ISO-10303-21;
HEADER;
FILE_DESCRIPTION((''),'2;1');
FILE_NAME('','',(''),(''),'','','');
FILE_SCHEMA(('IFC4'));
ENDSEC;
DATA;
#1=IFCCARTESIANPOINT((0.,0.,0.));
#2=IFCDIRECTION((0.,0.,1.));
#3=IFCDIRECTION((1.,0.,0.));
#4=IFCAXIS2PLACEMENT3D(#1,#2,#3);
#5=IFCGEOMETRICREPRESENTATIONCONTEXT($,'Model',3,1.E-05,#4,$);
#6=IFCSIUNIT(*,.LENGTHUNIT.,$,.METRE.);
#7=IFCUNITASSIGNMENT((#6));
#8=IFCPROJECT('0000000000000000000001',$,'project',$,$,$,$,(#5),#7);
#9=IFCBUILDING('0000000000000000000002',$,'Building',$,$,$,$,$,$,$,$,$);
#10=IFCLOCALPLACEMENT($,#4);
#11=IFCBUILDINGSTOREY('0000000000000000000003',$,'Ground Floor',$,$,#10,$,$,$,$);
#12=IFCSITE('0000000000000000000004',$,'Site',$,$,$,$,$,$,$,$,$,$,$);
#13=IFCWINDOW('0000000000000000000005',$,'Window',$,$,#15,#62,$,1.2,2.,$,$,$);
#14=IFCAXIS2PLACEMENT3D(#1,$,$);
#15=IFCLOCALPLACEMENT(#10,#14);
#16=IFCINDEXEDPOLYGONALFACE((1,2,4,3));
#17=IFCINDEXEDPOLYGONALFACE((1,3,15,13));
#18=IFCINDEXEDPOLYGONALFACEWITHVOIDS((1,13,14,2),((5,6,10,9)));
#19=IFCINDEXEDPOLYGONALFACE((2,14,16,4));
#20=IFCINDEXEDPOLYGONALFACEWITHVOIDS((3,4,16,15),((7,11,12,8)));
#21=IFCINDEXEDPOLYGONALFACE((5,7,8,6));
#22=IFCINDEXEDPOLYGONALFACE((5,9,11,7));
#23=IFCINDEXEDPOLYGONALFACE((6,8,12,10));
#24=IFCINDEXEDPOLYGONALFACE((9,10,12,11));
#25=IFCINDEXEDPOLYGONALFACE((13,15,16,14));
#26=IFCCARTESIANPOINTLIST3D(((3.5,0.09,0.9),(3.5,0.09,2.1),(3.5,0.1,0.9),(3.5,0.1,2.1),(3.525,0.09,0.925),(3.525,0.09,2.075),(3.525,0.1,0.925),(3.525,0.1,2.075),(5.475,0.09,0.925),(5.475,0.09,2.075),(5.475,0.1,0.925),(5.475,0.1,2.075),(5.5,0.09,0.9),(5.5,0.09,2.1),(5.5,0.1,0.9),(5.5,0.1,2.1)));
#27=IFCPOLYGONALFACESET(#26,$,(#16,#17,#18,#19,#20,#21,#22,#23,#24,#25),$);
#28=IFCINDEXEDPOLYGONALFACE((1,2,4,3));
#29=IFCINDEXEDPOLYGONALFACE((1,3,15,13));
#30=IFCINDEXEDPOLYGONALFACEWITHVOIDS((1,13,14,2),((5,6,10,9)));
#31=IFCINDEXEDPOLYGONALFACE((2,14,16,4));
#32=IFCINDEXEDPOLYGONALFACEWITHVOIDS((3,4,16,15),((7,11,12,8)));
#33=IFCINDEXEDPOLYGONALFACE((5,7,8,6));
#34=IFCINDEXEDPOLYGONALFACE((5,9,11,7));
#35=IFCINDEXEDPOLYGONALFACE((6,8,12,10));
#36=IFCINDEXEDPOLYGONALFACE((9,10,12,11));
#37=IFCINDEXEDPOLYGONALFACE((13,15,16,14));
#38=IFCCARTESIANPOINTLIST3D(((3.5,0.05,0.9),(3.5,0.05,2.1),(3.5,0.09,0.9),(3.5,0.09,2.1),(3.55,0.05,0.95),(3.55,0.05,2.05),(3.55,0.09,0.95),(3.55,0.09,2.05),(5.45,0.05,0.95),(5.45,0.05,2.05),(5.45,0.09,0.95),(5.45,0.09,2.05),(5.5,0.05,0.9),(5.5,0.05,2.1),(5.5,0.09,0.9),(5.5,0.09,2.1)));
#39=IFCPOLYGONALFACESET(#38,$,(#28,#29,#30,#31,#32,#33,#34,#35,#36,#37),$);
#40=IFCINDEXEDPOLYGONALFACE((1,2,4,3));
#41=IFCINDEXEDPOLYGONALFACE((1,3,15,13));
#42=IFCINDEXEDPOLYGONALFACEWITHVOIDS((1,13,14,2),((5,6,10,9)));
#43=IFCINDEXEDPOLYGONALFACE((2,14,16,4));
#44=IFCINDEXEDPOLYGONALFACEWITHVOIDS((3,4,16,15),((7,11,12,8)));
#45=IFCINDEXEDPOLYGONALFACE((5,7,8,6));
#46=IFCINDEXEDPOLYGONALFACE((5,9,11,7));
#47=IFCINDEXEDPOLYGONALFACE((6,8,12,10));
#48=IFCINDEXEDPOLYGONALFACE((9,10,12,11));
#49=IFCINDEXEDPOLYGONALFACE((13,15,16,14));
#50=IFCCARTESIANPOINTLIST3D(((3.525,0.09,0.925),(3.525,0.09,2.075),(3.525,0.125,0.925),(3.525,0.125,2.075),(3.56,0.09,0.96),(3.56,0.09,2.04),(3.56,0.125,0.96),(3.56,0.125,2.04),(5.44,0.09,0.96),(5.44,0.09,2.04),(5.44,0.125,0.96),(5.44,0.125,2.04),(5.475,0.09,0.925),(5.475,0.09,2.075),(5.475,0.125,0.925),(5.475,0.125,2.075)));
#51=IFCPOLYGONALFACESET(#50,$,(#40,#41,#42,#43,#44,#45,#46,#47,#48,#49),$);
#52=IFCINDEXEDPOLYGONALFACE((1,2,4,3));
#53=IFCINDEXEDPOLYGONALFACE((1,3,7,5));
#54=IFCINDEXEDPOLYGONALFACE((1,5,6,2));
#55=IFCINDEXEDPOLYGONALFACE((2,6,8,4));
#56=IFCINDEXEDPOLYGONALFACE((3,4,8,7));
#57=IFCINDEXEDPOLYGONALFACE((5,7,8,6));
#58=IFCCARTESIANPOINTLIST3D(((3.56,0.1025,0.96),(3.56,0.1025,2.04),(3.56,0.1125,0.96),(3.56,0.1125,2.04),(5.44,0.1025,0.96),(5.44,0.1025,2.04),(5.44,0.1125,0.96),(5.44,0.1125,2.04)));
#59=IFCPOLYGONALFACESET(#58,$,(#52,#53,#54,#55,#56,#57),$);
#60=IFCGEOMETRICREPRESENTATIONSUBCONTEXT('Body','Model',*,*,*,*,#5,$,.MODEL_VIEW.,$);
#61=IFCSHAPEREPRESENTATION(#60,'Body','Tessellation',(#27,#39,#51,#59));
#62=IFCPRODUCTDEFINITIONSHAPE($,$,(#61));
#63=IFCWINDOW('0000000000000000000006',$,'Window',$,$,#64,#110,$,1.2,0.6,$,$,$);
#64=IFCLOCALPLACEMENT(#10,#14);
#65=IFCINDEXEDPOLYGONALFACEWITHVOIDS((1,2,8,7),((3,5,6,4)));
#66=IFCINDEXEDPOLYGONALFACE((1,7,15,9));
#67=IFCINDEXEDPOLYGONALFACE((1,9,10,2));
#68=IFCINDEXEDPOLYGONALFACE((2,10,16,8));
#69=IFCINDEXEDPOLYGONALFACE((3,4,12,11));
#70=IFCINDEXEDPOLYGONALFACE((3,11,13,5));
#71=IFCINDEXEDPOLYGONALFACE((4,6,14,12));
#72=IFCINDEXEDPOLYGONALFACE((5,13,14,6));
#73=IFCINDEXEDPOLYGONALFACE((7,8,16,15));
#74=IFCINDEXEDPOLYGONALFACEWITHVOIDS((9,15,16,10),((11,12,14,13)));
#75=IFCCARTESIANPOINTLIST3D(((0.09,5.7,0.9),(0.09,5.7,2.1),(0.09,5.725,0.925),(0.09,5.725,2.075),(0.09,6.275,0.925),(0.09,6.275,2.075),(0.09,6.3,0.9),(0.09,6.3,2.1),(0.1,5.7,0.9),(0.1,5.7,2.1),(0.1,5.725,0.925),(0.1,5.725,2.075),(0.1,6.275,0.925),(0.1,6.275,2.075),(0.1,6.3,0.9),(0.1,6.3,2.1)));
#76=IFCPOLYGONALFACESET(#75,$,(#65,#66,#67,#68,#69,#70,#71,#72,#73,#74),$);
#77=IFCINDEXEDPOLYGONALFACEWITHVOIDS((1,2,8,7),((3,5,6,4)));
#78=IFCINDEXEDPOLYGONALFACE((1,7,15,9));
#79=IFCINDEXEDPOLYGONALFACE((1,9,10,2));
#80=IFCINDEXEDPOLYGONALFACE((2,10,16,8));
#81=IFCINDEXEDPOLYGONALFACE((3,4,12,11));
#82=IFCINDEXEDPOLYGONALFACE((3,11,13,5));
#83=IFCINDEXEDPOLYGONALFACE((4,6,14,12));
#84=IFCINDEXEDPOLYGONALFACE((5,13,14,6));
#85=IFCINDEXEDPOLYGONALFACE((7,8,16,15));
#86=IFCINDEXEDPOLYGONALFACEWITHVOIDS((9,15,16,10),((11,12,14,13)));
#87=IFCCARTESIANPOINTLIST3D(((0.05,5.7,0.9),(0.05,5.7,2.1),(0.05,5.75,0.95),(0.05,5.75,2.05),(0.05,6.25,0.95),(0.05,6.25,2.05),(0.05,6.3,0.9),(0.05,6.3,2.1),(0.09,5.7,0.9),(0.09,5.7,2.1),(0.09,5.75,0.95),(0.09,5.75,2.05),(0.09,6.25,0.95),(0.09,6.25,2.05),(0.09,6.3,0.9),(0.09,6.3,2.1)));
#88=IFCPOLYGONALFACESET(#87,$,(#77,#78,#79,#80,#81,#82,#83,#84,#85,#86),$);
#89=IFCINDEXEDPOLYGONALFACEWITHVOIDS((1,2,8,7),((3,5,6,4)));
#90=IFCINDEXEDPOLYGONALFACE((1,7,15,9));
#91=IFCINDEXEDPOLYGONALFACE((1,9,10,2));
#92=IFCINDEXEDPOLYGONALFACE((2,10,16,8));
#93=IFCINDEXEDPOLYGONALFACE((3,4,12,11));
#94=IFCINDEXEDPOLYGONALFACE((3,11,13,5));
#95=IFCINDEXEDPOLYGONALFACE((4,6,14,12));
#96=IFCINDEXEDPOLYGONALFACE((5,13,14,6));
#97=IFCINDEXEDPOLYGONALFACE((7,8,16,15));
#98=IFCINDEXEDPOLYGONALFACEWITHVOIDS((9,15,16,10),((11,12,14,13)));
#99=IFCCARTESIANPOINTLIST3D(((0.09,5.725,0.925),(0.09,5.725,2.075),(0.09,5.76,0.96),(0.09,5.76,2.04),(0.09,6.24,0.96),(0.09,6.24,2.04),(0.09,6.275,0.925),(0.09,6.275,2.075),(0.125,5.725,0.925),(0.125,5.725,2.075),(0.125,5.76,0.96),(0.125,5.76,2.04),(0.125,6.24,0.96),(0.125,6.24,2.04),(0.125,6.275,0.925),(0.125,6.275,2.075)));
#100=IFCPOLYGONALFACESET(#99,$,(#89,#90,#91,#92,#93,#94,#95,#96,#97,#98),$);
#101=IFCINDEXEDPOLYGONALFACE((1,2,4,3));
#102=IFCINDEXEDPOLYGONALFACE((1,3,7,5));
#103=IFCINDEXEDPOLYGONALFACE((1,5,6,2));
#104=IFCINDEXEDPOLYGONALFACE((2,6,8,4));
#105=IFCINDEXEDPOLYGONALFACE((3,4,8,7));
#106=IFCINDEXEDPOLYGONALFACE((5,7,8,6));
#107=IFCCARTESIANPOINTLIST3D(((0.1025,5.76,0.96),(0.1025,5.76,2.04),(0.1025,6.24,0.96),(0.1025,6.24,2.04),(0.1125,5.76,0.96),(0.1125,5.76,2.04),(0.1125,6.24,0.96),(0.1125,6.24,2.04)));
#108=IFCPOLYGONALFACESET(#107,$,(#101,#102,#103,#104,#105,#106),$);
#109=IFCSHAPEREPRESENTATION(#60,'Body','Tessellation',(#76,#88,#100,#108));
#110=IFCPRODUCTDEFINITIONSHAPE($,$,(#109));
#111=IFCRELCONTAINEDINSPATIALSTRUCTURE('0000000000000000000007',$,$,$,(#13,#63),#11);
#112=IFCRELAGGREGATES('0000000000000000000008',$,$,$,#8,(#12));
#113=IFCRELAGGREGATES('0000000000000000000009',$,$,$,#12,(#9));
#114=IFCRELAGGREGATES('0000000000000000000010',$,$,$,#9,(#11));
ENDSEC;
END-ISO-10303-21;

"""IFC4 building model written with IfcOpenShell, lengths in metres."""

from ifc_helpers import new_model, si_unit, frame, origin_with_axes, place, context, subcontext, project, spatial, line, indexed_curve, outline, extrude, element, save


model = new_model("IFC4")

# Units and contexts
model_context = context("Model", 3, precision=1e-05, world=origin_with_axes())
body_context = subcontext(model_context, "Body", "Model", "MODEL_VIEW")
ifc_project = project(units=[si_unit("LENGTHUNIT", "METRE")], contexts=[model_context])

# Site, building, storey
site = spatial("IfcSite", under=ifc_project, Name="Site")
building = spatial("IfcBuilding", under=site, Name="Building")
storey_placement = place(None, origin_with_axes())
storey = spatial("IfcBuildingStorey", under=building, at=storey_placement, Name="Ground Floor")

# Windows
window_1_placement = place(storey_placement, frame((3.5, 0.0, 0.9), z_axis=(0.0, 0.0, 1.0), x_axis=(1.0, 0.0, 0.0)))
element("IfcWindow", 1, at=window_1_placement, inside=storey, Name="Window", OverallHeight=1.2, OverallWidth=2.0, context=body_context, shape_type="SweptSolid", body=[
    extrude(outline(indexed_curve([(0.0, 0.0), (2.0, 0.0), (2.0, 1.2), (0.0, 1.2)], segments=[line(1, 2, 3, 4, 1)]), holes=[indexed_curve([(0.025, 0.025), (1.975, 0.025), (1.975, 1.175), (0.025, 1.175)], segments=[line(1, 2, 3, 4, 1)])]), frame((0.0, 0.09, 0.0), z_axis=(0.0, -1.0, 0.0), x_axis=(1.0, 0.0, 0.0)), (0.0, 0.0, -1.0), 0.01),
    extrude(outline(indexed_curve([(0.0, 0.0), (2.0, 0.0), (2.0, 1.2), (0.0, 1.2)], segments=[line(1, 2, 3, 4, 1)]), holes=[indexed_curve([(0.05, 0.05), (1.95, 0.05), (1.95, 1.15), (0.05, 1.15)], segments=[line(1, 2, 3, 4, 1)])]), frame((0.0, 0.05, 0.0), z_axis=(0.0, -1.0, 0.0), x_axis=(1.0, 0.0, 0.0)), (0.0, 0.0, -1.0), 0.04),
    extrude(outline(indexed_curve([(0.0, 0.0), (1.95, 0.0), (1.95, 1.15), (0.0, 1.15)], segments=[line(1, 2, 3, 4, 1)]), holes=[indexed_curve([(0.035, 0.035), (1.915, 0.035), (1.915, 1.115), (0.035, 1.115)], segments=[line(1, 2, 3, 4, 1)])]), frame((0.025, 0.09, 0.025), z_axis=(0.0, -1.0, 0.0), x_axis=(1.0, 0.0, 0.0)), (0.0, 0.0, -1.0), 0.035),
    extrude(outline(indexed_curve([(0.035, 0.035), (1.915, 0.035), (1.915, 1.115), (0.035, 1.115)], segments=[line(1, 2, 3, 4, 1)])), frame((0.025, 0.1025, 0.025), z_axis=(0.0, -1.0, 0.0), x_axis=(1.0, 0.0, 0.0)), (0.0, 0.0, -1.0), 0.01),
])
window_2_placement = place(storey_placement, frame((0.0, 6.3, 0.9), z_axis=(0.0, 0.0, 1.0), x_axis=(0.0, -1.0, 0.0)))
element("IfcWindow", 2, at=window_2_placement, inside=storey, Name="Window", OverallHeight=1.2, OverallWidth=0.6, context=body_context, shape_type="SweptSolid", body=[
    extrude(outline(indexed_curve([(0.0, 0.0), (0.6, 0.0), (0.6, 1.2), (0.0, 1.2)], segments=[line(1, 2, 3, 4, 1)]), holes=[indexed_curve([(0.025, 0.025), (0.575, 0.025), (0.575, 1.175), (0.025, 1.175)], segments=[line(1, 2, 3, 4, 1)])]), frame((0.0, 0.09, 0.0), z_axis=(0.0, -1.0, 0.0), x_axis=(1.0, 0.0, 0.0)), (0.0, 0.0, -1.0), 0.01),
    extrude(outline(indexed_curve([(0.0, 0.0), (0.6, 0.0), (0.6, 1.2), (0.0, 1.2)], segments=[line(1, 2, 3, 4, 1)]), holes=[indexed_curve([(0.05, 0.05), (0.55, 0.05), (0.55, 1.15), (0.05, 1.15)], segments=[line(1, 2, 3, 4, 1)])]), frame((0.0, 0.05, 0.0), z_axis=(0.0, -1.0, 0.0), x_axis=(1.0, 0.0, 0.0)), (0.0, 0.0, -1.0), 0.04),
    extrude(outline(indexed_curve([(0.0, 0.0), (0.55, 0.0), (0.55, 1.15), (0.0, 1.15)], segments=[line(1, 2, 3, 4, 1)]), holes=[indexed_curve([(0.035, 0.035), (0.515, 0.035), (0.515, 1.115), (0.035, 1.115)], segments=[line(1, 2, 3, 4, 1)])]), frame((0.025, 0.09, 0.025), z_axis=(0.0, -1.0, 0.0), x_axis=(1.0, 0.0, 0.0)), (0.0, 0.0, -1.0), 0.035),
    extrude(outline(indexed_curve([(0.035, 0.035), (0.515, 0.035), (0.515, 1.115), (0.035, 1.115)], segments=[line(1, 2, 3, 4, 1)])), frame((0.025, 0.1025, 0.025), z_axis=(0.0, -1.0, 0.0), x_axis=(1.0, 0.0, 0.0)), (0.0, 0.0, -1.0), 0.01),
])

save(model, "model.ifc")
